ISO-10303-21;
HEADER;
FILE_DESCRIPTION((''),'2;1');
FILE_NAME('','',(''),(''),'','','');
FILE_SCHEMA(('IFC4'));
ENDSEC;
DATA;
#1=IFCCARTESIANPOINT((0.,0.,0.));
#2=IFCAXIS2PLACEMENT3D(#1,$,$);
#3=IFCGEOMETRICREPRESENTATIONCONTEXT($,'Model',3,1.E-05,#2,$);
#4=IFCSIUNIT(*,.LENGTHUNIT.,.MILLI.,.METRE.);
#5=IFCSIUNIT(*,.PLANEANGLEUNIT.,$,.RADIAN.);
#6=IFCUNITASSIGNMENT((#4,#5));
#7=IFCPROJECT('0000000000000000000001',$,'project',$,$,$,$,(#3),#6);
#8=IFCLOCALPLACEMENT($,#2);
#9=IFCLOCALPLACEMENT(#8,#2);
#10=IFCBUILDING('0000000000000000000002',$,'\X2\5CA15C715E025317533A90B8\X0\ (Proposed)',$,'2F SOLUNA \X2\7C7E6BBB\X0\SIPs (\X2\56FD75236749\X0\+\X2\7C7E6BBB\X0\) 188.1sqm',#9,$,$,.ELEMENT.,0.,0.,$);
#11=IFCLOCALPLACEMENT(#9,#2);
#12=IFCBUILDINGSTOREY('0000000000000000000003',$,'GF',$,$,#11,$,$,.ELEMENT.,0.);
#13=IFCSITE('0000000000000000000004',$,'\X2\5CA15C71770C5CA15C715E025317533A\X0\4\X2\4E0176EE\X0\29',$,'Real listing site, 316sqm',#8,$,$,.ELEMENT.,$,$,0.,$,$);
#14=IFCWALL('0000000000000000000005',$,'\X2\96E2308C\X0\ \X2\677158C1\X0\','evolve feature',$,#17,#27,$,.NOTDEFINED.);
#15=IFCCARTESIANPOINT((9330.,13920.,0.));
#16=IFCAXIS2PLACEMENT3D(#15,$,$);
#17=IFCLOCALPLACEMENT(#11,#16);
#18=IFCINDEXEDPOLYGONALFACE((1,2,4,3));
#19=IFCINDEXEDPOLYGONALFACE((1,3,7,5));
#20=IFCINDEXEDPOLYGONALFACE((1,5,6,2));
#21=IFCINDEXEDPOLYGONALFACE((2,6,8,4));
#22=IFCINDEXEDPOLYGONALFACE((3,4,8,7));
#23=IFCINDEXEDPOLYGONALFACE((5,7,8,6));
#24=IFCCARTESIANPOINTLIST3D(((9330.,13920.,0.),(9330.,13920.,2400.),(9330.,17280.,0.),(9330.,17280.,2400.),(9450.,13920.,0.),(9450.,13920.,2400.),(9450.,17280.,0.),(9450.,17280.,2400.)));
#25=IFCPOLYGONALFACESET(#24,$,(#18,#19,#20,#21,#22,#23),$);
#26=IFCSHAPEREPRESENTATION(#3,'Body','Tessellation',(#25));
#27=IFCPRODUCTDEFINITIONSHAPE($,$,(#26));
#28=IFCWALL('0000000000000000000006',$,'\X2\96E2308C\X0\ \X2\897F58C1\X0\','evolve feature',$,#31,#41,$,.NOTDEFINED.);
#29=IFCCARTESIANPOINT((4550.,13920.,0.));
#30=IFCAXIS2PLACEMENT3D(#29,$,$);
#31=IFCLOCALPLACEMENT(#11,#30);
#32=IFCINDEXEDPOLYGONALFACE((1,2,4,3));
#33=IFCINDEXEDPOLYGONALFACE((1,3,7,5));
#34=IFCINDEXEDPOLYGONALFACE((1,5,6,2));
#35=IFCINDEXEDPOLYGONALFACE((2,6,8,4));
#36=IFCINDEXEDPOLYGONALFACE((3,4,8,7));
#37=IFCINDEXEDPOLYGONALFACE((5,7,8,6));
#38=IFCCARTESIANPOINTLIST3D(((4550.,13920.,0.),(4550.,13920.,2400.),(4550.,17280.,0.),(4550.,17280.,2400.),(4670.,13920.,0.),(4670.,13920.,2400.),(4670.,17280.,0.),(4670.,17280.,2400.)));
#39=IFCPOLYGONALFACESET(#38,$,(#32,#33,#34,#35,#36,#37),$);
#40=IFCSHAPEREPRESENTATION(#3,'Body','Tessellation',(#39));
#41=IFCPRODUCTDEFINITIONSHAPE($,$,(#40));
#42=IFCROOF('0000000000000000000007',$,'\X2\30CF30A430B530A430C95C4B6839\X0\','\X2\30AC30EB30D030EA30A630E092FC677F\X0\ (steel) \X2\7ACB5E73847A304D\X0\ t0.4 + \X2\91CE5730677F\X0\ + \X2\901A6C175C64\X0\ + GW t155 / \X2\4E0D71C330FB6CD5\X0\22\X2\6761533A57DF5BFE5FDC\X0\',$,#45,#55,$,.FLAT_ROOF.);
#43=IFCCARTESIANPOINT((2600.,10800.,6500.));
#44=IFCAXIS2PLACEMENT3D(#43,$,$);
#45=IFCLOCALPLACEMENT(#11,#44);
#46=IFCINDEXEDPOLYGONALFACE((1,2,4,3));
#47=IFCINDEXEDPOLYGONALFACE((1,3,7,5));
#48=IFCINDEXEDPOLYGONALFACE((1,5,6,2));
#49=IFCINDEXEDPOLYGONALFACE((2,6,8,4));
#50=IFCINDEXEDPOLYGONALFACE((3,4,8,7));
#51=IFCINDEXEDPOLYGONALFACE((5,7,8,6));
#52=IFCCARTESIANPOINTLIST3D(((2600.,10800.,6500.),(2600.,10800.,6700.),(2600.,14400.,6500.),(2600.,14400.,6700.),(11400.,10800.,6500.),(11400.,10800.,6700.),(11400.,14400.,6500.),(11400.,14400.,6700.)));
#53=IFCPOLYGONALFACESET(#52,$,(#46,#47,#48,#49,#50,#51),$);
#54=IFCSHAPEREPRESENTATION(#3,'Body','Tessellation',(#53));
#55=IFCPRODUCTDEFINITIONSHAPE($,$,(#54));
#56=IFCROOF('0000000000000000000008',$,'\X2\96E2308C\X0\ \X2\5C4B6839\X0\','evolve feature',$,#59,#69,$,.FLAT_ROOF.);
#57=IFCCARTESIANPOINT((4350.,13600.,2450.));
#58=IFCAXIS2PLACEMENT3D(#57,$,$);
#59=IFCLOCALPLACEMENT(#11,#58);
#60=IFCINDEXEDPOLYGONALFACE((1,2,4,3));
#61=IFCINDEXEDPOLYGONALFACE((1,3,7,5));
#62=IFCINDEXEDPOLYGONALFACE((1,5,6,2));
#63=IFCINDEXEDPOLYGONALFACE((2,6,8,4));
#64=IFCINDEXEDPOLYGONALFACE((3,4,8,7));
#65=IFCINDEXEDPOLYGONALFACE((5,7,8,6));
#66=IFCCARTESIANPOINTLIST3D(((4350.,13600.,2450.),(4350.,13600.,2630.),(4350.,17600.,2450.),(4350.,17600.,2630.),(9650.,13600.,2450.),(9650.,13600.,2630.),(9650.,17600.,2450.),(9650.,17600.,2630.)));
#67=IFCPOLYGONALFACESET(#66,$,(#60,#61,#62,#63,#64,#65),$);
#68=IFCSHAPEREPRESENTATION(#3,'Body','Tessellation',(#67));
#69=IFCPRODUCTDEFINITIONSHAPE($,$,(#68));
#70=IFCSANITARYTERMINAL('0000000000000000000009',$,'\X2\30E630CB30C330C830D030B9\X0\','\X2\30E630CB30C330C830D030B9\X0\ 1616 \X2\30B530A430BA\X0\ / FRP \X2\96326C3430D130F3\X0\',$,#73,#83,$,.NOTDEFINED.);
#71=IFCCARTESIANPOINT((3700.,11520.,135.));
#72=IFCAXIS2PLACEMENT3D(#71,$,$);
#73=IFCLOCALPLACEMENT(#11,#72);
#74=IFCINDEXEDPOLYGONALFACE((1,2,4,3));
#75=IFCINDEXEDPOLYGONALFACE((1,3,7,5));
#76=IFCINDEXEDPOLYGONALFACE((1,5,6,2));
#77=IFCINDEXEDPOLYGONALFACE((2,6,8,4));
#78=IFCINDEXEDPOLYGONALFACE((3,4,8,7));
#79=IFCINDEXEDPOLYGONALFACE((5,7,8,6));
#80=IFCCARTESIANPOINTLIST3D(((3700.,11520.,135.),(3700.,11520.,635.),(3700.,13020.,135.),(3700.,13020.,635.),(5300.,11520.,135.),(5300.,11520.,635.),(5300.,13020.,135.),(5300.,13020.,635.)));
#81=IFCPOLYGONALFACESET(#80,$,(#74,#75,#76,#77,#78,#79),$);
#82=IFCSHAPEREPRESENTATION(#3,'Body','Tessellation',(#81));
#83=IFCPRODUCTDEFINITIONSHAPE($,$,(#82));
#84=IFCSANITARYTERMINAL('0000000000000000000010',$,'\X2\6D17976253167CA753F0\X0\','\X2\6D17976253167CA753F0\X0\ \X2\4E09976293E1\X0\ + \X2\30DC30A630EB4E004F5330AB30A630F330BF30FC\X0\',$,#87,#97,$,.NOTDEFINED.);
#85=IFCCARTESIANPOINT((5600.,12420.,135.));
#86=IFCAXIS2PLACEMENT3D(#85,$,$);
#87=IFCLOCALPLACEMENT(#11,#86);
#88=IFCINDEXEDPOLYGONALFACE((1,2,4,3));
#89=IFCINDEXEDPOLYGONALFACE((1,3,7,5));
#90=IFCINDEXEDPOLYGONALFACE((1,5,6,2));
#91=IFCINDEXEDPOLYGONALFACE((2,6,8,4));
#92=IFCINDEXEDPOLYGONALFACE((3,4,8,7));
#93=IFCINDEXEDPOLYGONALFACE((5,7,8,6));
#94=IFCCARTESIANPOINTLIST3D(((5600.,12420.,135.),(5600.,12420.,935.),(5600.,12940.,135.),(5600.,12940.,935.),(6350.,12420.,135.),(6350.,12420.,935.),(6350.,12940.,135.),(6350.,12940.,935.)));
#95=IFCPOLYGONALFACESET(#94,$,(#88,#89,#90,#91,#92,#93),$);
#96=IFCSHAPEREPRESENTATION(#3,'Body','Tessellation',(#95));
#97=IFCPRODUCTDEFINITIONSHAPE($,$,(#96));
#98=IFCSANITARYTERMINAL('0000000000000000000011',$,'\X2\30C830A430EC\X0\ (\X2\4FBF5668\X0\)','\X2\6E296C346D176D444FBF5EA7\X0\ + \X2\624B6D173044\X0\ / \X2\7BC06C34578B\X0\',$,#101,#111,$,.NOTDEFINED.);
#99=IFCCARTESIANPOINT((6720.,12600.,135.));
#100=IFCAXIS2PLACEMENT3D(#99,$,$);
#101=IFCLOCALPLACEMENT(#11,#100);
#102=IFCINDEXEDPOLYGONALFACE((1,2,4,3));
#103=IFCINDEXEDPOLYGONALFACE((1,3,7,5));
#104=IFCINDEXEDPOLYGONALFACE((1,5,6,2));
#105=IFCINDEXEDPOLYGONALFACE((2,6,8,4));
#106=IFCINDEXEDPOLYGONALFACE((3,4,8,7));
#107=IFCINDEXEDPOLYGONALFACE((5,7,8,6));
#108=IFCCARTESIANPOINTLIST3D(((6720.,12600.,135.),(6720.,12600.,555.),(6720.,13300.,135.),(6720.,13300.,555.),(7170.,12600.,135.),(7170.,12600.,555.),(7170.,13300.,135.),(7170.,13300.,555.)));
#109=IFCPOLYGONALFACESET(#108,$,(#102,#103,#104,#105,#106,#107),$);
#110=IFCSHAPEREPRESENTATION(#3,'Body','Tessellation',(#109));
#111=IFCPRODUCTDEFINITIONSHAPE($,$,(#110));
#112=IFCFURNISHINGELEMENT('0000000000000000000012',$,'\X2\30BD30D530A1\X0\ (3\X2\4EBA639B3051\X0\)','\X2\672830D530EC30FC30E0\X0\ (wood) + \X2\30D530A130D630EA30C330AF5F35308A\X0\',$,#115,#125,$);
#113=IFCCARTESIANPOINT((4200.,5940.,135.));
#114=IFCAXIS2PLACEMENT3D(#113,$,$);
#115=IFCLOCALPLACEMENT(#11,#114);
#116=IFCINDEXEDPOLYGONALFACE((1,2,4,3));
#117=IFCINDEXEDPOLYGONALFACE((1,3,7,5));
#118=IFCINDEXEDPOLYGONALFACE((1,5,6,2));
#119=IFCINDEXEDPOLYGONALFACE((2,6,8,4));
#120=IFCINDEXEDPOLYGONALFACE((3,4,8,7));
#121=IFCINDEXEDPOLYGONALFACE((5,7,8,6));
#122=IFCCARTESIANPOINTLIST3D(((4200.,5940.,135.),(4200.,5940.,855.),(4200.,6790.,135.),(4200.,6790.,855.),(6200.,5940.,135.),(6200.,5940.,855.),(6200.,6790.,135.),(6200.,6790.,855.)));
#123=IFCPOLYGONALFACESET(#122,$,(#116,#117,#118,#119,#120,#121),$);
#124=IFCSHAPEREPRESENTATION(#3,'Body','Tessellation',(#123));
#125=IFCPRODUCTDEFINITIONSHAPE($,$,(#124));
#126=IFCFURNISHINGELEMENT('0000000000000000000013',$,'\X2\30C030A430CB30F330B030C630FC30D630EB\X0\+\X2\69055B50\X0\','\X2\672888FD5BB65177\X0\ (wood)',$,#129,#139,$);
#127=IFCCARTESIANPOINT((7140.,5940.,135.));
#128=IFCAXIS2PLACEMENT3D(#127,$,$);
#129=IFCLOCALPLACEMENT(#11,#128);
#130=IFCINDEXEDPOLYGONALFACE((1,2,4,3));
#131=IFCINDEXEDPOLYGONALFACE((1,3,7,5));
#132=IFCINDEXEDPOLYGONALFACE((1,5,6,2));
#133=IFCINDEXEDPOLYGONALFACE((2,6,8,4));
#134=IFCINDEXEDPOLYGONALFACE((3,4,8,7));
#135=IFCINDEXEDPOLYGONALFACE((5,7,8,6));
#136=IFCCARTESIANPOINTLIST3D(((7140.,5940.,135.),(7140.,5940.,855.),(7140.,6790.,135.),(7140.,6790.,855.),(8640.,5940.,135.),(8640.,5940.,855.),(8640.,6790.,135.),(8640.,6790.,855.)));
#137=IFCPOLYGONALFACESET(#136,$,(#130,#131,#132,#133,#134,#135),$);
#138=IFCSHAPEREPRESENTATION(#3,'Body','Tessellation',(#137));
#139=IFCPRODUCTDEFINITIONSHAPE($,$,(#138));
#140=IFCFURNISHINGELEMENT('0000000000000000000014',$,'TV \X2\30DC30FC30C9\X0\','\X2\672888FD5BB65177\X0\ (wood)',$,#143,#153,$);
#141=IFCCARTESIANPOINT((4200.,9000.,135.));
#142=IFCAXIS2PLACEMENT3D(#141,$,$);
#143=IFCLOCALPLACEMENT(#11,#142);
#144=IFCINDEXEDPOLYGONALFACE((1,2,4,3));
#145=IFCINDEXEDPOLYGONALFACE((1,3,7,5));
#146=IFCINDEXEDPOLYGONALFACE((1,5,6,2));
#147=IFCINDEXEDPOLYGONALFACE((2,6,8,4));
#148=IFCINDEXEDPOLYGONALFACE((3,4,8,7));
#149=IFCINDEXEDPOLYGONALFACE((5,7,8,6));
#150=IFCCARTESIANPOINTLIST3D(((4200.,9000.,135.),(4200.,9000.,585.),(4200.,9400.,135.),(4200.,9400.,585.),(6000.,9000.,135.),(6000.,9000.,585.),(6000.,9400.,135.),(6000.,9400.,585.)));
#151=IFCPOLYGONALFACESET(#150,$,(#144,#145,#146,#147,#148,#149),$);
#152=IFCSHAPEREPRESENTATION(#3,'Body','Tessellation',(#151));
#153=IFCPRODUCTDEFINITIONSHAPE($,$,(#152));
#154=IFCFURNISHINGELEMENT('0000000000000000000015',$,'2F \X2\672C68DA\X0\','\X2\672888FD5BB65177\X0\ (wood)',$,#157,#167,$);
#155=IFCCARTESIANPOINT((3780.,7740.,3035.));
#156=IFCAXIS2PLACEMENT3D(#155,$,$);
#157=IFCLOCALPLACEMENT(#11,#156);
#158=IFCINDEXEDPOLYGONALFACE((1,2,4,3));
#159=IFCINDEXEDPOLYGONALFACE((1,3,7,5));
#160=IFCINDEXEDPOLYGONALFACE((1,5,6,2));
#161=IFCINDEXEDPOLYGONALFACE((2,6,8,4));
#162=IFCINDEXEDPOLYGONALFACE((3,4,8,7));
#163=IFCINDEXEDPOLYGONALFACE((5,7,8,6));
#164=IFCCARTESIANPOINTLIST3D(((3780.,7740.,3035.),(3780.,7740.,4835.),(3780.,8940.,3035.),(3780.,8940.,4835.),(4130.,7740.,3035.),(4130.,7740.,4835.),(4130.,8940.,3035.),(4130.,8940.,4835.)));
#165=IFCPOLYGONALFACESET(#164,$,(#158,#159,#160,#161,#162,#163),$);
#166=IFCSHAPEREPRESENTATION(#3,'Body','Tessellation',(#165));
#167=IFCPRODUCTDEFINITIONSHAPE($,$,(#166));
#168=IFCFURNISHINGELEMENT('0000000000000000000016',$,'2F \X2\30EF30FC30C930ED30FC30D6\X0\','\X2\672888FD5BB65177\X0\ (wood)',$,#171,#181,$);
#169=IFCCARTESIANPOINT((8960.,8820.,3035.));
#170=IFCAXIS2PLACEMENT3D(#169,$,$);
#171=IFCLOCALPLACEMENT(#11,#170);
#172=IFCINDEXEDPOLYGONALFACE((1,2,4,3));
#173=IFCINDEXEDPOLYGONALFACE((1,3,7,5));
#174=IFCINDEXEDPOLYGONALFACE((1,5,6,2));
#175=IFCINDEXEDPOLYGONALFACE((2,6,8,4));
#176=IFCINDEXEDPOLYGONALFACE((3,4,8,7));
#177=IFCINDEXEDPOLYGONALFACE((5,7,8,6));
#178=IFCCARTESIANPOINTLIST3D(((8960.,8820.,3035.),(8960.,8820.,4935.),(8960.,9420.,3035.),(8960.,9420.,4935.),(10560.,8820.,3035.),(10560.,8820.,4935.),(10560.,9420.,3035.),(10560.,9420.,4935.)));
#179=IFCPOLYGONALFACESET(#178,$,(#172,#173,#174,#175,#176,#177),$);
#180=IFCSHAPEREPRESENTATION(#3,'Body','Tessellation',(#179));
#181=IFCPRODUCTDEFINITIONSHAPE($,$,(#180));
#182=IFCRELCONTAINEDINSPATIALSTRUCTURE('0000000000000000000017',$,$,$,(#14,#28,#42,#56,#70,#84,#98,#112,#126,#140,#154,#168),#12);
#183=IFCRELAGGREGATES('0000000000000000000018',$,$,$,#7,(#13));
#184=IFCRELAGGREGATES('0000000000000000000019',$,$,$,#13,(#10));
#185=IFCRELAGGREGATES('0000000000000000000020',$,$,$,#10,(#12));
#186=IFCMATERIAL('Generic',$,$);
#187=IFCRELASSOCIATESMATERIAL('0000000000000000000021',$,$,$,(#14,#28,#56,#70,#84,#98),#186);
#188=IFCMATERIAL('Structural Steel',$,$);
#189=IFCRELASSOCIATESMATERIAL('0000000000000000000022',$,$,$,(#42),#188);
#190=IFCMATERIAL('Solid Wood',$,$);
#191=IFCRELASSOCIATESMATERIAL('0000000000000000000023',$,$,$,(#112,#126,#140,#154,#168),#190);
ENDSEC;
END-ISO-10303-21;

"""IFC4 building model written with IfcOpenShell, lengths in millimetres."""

from ifc_helpers import new_model, si_unit, frame, frame_2d, origin, place, context, project, spatial, rectangle, extrude, material, element, save


model = new_model("IFC4")

# Units and contexts
model_context = context("Model", 3, precision=1e-05, world=origin())
ifc_project = project(units=[si_unit("LENGTHUNIT", "METRE", prefix="MILLI"), si_unit("PLANEANGLEUNIT", "RADIAN")], contexts=[model_context])

# Site, building, storey
site_placement = place(None, origin())
site = spatial("IfcSite", under=ifc_project, at=site_placement, Name="岡山県岡山市北区4丁目29", ObjectType="Real listing site, 316sqm", CompositionType="ELEMENT", RefElevation=0.0)
building_placement = place(site_placement, origin())
building = spatial("IfcBuilding", under=site, at=building_placement, Name="岡山市北区邸 (Proposed)", ObjectType="2F SOLUNA 籾殻SIPs (国産杉+籾殻) 188.1sqm", CompositionType="ELEMENT", ElevationOfRefHeight=0.0, ElevationOfTerrain=0.0)
storey_placement = place(building_placement, origin())
storey = spatial("IfcBuildingStorey", under=building, at=storey_placement, Name="GF", CompositionType="ELEMENT", Elevation=0.0)

# Shared definitions
ifc_material_1 = material(Name="Generic")

# Shared definitions
ifc_material_2 = material(Name="Solid Wood")

# Walls
wall_1_placement = place(storey_placement, frame((9330.0, 13920.0, 0.0)))
element("IfcWall", 1, at=wall_1_placement, inside=storey, material=ifc_material_1, Name="離れ 東壁", Description="evolve feature", PredefinedType="NOTDEFINED", context=model_context, shape_type="SweptSolid", body=[
    extrude(rectangle(XDim=120.0, YDim=3360.0, at=frame_2d((60.0, 1680.0))), frame((9330.0, 13920.0, 0.0)), (0.0, 0.0, 1.0), 2400.0),
])
wall_2_placement = place(storey_placement, frame((4550.0, 13920.0, 0.0)))
element("IfcWall", 2, at=wall_2_placement, inside=storey, material=ifc_material_1, Name="離れ 西壁", Description="evolve feature", PredefinedType="NOTDEFINED", context=model_context, shape_type="SweptSolid", body=[
    extrude(rectangle(XDim=120.0, YDim=3360.0, at=frame_2d((60.0, 1680.0))), frame((4550.0, 13920.0, 0.0)), (0.0, 0.0, 1.0), 2400.0),
])

# Roofs
ifc_material_3 = material(Name="Structural Steel")
roof_1_placement = place(storey_placement, frame((2600.0, 10800.0, 6500.0)))
element("IfcRoof", 3, at=roof_1_placement, inside=storey, material=ifc_material_3, Name="ハイサイド屋根", Description="ガルバリウム鋼板 (steel) 立平葺き t0.4 + 野地板 + 通気層 + GW t155 / 不燃・法22条区域対応", PredefinedType="FLAT_ROOF", context=model_context, shape_type="SweptSolid", body=[
    extrude(rectangle(XDim=8800.0, YDim=3600.0, at=frame_2d((4400.0, 1800.0))), frame((2600.0, 10800.0, 6500.0)), (0.0, 0.0, 1.0), 200.0),
])
roof_2_placement = place(storey_placement, frame((4350.0, 13600.0, 2450.0)))
element("IfcRoof", 4, at=roof_2_placement, inside=storey, material=ifc_material_1, Name="離れ 屋根", Description="evolve feature", PredefinedType="FLAT_ROOF", context=model_context, shape_type="SweptSolid", body=[
    extrude(rectangle(XDim=5300.0, YDim=4000.0, at=frame_2d((2650.0, 2000.0))), frame((4350.0, 13600.0, 2450.0)), (0.0, 0.0, 1.0), 180.0),
])

# Sanitary terminals
sanitary_terminal_1_placement = place(storey_placement, frame((3700.0, 11520.0, 135.0)))
element("IfcSanitaryTerminal", 5, at=sanitary_terminal_1_placement, inside=storey, material=ifc_material_1, Name="ユニットバス", Description="ユニットバス 1616 サイズ / FRP 防水パン", PredefinedType="NOTDEFINED", context=model_context, shape_type="SweptSolid", body=[
    extrude(rectangle(XDim=1600.0, YDim=1500.0, at=frame_2d((800.0, 750.0))), frame((3700.0, 11520.0, 135.0)), (0.0, 0.0, 1.0), 500.0),
])
sanitary_terminal_2_placement = place(storey_placement, frame((5600.0, 12420.0, 135.0)))
element("IfcSanitaryTerminal", 6, at=sanitary_terminal_2_placement, inside=storey, material=ifc_material_1, Name="洗面化粧台", Description="洗面化粧台 三面鏡 + ボウル一体カウンター", PredefinedType="NOTDEFINED", context=model_context, shape_type="SweptSolid", body=[
    extrude(rectangle(XDim=750.0, YDim=520.0, at=frame_2d((375.0, 260.0))), frame((5600.0, 12420.0, 135.0)), (0.0, 0.0, 1.0), 800.0),
])
sanitary_terminal_3_placement = place(storey_placement, frame((6720.0, 12600.0, 135.0)))
element("IfcSanitaryTerminal", 7, at=sanitary_terminal_3_placement, inside=storey, material=ifc_material_1, Name="トイレ (便器)", Description="温水洗浄便座 + 手洗い / 節水型", PredefinedType="NOTDEFINED", context=model_context, shape_type="SweptSolid", body=[
    extrude(rectangle(XDim=450.0, YDim=700.0, at=frame_2d((225.0, 350.0))), frame((6720.0, 12600.0, 135.0)), (0.0, 0.0, 1.0), 420.0),
])

# Furnishing elements
furnishing_1_placement = place(storey_placement, frame((4200.0, 5940.0, 135.0)))
element("IfcFurnishingElement", 8, at=furnishing_1_placement, inside=storey, material=ifc_material_2, Name="ソファ (3人掛け)", Description="木フレーム (wood) + ファブリック張り", context=model_context, shape_type="SweptSolid", body=[
    extrude(rectangle(XDim=2000.0, YDim=850.0, at=frame_2d((1000.0, 425.0))), frame((4200.0, 5940.0, 135.0)), (0.0, 0.0, 1.0), 720.0),
])
furnishing_2_placement = place(storey_placement, frame((7140.0, 5940.0, 135.0)))
element("IfcFurnishingElement", 9, at=furnishing_2_placement, inside=storey, material=ifc_material_2, Name="ダイニングテーブル+椅子", Description="木製家具 (wood)", context=model_context, shape_type="SweptSolid", body=[
    extrude(rectangle(XDim=1500.0, YDim=850.0, at=frame_2d((750.0, 425.0))), frame((7140.0, 5940.0, 135.0)), (0.0, 0.0, 1.0), 720.0),
])
furnishing_3_placement = place(storey_placement, frame((4200.0, 9000.0, 135.0)))
element("IfcFurnishingElement", 10, at=furnishing_3_placement, inside=storey, material=ifc_material_2, Name="TV ボード", Description="木製家具 (wood)", context=model_context, shape_type="SweptSolid", body=[
    extrude(rectangle(XDim=1800.0, YDim=400.0, at=frame_2d((900.0, 200.0))), frame((4200.0, 9000.0, 135.0)), (0.0, 0.0, 1.0), 450.0),
])
furnishing_4_placement = place(storey_placement, frame((3780.0, 7740.0, 3035.0)))
element("IfcFurnishingElement", 11, at=furnishing_4_placement, inside=storey, material=ifc_material_2, Name="2F 本棚", Description="木製家具 (wood)", context=model_context, shape_type="SweptSolid", body=[
    extrude(rectangle(XDim=350.0, YDim=1200.0, at=frame_2d((175.0, 600.0))), frame((3780.0, 7740.0, 3035.0)), (0.0, 0.0, 1.0), 1800.0),
])
furnishing_5_placement = place(storey_placement, frame((8960.0, 8820.0, 3035.0)))
element("IfcFurnishingElement", 12, at=furnishing_5_placement, inside=storey, material=ifc_material_2, Name="2F ワードローブ", Description="木製家具 (wood)", context=model_context, shape_type="SweptSolid", body=[
    extrude(rectangle(XDim=1600.0, YDim=600.0, at=frame_2d((800.0, 300.0))), frame((8960.0, 8820.0, 3035.0)), (0.0, 0.0, 1.0), 1900.0),
])

save(model, "model.ifc")
